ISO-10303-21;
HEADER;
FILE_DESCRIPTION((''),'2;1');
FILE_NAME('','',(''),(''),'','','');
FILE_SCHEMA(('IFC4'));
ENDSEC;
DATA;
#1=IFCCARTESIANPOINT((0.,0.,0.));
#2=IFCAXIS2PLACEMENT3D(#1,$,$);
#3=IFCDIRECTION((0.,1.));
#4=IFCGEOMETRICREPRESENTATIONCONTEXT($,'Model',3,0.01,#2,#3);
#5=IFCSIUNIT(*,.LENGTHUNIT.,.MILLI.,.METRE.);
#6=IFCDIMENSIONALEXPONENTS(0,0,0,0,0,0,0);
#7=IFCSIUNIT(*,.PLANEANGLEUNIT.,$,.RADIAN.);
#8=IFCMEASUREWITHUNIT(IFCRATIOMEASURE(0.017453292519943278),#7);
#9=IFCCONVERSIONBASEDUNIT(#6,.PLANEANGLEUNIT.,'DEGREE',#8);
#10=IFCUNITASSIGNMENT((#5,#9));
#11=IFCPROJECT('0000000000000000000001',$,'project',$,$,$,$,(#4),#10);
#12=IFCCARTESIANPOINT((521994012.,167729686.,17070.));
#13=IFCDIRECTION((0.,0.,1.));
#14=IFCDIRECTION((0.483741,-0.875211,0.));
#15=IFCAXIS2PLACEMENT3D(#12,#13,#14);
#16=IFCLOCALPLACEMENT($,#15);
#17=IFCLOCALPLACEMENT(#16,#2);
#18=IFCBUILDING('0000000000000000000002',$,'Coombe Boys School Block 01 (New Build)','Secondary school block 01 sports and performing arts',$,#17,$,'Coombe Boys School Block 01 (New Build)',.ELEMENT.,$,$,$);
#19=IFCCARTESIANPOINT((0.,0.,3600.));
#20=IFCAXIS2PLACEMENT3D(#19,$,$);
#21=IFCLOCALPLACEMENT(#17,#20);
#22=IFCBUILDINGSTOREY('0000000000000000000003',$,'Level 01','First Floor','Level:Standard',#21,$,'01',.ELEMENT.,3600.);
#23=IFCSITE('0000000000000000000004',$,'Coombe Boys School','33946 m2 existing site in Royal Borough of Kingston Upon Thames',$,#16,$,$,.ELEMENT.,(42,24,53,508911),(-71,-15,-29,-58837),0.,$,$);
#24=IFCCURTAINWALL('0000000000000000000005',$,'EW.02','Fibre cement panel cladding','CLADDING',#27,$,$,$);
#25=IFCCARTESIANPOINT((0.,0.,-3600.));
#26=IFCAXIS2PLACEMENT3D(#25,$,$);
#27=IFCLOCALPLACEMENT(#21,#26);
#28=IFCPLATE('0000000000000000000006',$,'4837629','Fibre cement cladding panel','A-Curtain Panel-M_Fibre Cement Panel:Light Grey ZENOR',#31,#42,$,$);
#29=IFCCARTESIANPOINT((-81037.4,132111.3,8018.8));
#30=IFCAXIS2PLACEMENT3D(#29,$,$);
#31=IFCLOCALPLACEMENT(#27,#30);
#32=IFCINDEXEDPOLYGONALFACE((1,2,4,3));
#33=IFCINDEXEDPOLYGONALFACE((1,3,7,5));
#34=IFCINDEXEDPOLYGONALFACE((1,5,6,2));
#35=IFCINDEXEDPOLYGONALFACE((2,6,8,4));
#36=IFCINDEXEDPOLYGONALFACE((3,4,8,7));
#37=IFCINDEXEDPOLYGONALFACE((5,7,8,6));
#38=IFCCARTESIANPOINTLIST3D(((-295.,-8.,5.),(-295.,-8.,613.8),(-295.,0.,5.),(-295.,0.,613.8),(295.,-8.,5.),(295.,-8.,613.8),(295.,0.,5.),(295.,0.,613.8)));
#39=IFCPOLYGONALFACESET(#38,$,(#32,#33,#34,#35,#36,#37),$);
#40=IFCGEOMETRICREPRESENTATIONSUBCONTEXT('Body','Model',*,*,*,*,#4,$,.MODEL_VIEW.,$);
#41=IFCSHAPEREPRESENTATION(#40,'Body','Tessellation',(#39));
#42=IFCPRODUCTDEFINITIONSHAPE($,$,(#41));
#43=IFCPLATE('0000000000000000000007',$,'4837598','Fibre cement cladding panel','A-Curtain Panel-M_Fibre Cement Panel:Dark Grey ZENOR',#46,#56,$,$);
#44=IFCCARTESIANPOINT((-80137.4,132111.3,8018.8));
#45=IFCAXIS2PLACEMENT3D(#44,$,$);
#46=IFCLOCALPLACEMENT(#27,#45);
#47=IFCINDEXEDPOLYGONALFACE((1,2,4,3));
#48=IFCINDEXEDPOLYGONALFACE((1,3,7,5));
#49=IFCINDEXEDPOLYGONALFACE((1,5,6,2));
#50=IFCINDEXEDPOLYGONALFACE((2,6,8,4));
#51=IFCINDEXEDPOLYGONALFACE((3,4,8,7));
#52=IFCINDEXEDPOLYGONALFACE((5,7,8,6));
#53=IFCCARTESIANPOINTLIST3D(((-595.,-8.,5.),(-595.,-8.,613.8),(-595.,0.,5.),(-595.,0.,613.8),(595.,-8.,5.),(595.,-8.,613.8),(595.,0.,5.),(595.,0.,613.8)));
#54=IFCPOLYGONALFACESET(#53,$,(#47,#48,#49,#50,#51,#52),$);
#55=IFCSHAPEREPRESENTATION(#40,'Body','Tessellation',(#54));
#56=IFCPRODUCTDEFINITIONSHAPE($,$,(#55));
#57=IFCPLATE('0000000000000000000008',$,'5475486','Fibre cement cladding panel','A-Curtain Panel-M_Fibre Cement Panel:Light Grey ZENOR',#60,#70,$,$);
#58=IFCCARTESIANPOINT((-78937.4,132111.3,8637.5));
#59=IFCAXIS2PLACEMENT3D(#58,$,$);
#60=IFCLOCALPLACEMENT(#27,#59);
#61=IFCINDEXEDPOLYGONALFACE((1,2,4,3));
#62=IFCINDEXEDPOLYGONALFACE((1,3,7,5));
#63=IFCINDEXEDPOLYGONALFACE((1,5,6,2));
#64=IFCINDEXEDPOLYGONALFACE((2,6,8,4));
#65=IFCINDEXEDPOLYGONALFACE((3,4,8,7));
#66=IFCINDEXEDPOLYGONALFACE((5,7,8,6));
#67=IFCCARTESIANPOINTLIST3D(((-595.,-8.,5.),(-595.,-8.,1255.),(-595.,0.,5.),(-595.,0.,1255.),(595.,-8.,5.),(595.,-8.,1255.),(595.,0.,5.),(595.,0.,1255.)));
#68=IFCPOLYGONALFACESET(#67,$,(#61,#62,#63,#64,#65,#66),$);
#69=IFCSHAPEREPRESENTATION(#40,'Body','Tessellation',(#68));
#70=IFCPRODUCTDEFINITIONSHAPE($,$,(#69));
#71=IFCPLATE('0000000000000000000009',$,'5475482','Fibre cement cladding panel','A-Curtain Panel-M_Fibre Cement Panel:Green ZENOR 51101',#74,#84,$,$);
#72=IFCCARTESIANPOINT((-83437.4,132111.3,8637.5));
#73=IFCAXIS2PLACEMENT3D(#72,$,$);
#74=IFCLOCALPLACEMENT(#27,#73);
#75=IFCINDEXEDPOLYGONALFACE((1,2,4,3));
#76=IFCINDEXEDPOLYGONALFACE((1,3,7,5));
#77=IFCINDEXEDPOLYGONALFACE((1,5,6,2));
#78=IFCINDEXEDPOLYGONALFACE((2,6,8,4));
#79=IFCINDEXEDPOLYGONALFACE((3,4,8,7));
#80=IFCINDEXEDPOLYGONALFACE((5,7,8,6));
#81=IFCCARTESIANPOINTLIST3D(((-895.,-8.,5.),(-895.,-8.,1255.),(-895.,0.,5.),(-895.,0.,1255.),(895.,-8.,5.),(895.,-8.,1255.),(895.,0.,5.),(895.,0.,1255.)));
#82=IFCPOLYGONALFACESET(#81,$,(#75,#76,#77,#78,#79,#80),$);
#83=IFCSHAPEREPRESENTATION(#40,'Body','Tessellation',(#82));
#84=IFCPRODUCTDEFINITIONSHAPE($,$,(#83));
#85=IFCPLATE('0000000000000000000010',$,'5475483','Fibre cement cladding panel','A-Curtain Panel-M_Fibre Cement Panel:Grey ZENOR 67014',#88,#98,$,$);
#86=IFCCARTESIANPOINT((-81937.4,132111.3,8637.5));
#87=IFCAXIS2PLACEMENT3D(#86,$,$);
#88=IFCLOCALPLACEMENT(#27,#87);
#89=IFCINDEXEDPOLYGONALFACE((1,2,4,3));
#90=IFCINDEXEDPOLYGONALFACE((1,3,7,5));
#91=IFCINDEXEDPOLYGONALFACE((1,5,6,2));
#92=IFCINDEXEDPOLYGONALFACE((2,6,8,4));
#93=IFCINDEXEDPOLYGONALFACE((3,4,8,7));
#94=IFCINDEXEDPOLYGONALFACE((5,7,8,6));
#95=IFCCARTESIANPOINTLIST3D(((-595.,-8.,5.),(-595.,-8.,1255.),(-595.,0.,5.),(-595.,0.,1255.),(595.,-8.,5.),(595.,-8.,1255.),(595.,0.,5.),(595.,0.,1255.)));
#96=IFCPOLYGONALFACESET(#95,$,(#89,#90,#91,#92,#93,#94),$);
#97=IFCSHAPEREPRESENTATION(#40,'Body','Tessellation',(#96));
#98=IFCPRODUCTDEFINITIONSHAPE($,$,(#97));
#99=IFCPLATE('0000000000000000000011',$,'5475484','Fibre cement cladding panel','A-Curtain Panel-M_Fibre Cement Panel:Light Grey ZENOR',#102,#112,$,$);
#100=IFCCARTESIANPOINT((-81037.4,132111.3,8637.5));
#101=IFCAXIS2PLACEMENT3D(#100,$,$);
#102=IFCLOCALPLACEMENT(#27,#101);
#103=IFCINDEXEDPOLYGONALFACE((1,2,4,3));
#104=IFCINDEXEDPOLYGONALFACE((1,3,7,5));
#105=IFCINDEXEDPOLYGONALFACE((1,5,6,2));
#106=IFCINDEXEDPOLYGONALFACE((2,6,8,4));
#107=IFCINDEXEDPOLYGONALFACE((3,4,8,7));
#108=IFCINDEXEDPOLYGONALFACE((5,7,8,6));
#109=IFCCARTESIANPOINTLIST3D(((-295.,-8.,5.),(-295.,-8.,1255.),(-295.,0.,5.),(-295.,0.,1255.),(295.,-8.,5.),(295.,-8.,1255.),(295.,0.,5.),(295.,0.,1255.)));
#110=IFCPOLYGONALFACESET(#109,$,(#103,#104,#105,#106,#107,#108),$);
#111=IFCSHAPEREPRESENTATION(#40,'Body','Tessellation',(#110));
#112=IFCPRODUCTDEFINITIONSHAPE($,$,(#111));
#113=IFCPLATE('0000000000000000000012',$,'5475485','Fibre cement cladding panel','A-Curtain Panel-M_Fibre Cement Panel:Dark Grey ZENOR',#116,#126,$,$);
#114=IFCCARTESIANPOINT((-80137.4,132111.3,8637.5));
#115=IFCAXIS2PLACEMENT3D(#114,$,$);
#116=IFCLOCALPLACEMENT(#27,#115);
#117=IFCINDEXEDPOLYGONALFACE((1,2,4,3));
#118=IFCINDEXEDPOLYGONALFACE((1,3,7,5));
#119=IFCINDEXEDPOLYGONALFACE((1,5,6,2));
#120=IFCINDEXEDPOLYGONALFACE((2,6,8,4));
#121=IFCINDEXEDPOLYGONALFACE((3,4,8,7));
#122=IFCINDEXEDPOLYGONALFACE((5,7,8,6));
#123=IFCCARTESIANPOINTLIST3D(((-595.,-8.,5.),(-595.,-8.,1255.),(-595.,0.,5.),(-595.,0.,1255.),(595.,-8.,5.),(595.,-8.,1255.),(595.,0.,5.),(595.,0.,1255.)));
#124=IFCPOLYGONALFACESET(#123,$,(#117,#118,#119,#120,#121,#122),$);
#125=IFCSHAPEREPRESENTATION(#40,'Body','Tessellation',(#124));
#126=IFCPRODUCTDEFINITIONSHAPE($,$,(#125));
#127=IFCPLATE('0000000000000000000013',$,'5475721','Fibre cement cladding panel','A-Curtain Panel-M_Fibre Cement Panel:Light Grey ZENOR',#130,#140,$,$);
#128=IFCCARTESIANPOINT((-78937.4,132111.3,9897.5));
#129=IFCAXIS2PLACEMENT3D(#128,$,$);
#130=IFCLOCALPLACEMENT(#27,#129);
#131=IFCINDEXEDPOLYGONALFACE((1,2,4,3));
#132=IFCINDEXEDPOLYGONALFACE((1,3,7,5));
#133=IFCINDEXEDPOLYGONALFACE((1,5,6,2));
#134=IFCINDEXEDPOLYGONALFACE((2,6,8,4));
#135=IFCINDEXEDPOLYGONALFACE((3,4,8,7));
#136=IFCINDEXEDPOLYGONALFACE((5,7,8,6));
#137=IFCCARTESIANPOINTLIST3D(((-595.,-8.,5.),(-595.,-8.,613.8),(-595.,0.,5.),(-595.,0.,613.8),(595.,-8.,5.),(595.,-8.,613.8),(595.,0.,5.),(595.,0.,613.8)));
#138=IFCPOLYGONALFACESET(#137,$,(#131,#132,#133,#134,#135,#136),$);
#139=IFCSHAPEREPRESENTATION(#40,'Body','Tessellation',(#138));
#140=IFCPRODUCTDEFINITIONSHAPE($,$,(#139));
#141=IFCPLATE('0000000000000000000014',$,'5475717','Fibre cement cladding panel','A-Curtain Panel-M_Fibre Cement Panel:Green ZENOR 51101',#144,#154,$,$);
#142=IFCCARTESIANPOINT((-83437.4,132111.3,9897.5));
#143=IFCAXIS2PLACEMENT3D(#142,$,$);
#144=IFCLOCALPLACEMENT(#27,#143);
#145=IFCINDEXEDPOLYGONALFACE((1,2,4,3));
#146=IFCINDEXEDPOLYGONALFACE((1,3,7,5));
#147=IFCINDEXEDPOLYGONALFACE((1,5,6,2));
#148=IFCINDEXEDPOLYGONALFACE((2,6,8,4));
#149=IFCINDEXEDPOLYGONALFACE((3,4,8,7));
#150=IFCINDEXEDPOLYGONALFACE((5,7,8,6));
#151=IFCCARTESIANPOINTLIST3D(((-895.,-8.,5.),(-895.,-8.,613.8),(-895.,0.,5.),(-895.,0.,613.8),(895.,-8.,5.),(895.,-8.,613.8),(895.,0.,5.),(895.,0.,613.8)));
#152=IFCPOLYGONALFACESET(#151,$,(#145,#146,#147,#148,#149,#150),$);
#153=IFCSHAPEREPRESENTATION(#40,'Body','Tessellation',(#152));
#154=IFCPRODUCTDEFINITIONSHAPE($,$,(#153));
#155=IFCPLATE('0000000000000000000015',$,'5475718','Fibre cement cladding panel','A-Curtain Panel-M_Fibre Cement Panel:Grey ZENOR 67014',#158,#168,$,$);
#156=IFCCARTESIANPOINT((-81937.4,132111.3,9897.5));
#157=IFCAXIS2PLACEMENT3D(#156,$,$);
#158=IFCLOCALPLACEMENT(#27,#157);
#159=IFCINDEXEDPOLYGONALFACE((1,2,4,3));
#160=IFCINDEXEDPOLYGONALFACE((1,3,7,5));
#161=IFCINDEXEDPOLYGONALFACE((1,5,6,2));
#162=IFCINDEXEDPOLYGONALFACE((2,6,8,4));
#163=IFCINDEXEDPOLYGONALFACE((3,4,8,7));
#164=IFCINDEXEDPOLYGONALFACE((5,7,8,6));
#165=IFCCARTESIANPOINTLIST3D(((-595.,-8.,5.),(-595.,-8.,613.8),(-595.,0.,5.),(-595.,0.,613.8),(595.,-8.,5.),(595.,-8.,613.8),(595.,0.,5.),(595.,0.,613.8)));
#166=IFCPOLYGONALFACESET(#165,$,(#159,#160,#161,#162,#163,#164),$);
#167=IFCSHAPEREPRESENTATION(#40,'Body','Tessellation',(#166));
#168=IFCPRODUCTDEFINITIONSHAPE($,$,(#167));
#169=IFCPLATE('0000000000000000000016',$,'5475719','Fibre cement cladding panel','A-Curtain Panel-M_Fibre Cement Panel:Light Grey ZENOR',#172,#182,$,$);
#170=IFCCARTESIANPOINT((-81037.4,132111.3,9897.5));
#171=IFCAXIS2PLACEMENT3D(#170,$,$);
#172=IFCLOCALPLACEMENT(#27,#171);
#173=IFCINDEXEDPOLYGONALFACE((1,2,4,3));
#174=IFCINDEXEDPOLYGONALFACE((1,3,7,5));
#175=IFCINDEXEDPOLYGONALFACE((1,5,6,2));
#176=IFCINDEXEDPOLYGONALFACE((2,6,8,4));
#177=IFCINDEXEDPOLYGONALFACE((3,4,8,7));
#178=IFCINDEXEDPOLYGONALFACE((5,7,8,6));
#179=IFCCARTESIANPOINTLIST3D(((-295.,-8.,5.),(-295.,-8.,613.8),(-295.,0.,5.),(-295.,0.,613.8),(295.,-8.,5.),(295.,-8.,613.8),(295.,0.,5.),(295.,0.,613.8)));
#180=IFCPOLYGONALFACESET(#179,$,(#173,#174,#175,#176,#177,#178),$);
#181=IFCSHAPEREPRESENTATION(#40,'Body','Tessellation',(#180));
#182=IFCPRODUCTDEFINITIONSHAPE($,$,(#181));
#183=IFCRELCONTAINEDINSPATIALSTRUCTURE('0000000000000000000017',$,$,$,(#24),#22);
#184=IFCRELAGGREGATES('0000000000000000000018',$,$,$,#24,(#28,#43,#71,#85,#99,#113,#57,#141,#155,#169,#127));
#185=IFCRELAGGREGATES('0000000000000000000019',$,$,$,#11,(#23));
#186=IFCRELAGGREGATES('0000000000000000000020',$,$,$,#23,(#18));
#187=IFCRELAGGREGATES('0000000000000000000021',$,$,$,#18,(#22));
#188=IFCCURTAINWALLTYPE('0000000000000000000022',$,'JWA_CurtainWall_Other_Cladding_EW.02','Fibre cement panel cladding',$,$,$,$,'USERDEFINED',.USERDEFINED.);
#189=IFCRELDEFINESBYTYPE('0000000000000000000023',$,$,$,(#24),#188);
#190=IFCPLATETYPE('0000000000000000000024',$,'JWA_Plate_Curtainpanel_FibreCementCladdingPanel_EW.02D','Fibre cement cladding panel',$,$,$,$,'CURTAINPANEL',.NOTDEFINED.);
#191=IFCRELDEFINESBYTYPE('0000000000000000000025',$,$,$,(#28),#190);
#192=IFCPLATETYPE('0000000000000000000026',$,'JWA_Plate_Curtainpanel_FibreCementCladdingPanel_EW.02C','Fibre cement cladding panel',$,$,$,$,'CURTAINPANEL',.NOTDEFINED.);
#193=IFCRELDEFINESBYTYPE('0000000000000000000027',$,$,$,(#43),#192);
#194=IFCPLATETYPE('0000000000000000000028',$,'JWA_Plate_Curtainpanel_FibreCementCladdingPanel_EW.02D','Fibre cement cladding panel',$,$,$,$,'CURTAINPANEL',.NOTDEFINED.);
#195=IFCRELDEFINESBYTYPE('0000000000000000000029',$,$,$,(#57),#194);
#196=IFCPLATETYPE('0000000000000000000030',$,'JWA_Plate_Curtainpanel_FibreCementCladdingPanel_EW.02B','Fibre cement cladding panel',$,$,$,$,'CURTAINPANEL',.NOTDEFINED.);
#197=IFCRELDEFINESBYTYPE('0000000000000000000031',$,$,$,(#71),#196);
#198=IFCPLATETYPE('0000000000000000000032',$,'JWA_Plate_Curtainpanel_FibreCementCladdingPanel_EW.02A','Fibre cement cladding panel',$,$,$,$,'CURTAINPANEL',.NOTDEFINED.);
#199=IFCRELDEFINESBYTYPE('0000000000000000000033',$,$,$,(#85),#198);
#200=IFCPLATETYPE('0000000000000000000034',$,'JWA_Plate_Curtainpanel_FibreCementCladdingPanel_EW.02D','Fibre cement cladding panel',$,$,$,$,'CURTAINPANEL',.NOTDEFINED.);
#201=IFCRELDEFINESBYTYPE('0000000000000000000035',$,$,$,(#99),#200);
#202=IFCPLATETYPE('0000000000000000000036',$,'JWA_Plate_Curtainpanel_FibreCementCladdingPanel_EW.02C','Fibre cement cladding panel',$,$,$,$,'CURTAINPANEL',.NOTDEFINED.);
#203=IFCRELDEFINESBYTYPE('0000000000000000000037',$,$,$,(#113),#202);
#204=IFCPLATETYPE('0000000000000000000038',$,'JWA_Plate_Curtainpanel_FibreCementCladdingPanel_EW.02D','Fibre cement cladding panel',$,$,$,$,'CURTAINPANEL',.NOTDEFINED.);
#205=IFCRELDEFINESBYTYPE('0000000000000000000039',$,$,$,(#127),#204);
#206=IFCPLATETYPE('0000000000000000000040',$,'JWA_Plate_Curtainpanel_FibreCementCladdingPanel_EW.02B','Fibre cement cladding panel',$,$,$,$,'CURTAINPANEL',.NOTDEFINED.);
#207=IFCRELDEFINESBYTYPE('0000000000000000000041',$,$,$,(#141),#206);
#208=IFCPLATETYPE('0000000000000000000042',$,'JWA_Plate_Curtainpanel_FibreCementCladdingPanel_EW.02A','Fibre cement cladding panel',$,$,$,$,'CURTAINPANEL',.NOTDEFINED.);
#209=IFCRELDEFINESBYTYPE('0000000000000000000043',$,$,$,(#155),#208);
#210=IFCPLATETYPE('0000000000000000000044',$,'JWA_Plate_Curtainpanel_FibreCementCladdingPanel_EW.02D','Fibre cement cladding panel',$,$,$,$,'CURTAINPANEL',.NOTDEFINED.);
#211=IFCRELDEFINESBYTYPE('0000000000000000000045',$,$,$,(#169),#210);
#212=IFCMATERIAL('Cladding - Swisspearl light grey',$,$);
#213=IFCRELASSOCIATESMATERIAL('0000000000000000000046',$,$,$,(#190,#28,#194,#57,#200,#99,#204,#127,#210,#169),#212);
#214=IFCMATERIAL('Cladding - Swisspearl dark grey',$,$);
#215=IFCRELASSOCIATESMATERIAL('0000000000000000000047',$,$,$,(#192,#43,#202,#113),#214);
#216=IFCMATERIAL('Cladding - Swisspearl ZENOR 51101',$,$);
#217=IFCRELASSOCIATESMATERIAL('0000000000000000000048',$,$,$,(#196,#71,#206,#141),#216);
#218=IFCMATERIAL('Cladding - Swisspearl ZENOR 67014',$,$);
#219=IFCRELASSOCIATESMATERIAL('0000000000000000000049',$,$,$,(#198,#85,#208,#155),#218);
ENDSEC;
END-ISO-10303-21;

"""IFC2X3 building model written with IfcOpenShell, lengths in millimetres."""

from ifc_helpers import new_model, entity, si_unit, converted_unit, direction, frame, origin, origin_2d_with_axis, place, context, subcontext, project, spatial, rectangle, extrude, source, transform, mapped, material, type_object, type_shapes, element, aggregate, save


model = new_model("IFC2X3")

# Units and contexts
model_context = context("Model", 3, precision=0.01, world=origin(), true_north=direction((0.0, 1.0)))
body_context = subcontext(model_context, "Body", "Model", "MODEL_VIEW")
ifc_project = project(units=[si_unit("LENGTHUNIT", "METRE", prefix="MILLI"), converted_unit("PLANEANGLEUNIT", "DEGREE", entity("IfcRatioMeasure", 0.017453292519943278), si_unit("PLANEANGLEUNIT", "RADIAN"), dimensions=[0, 0, 0, 0, 0, 0, 0])], contexts=[model_context])

# Site, building, storey
site_placement = place(None, frame((521994012.0, 167729686.0, 17070.0), z_axis=(0.0, 0.0, 1.0), x_axis=(0.483741, -0.875211, 0.0)))
site = spatial("IfcSite", under=ifc_project, at=site_placement, Name="Coombe Boys School", Description="33946 m2 existing site in Royal Borough of Kingston Upon Thames", CompositionType="ELEMENT", RefLatitude=(42, 24, 53, 508911), RefLongitude=(-71, -15, -29, -58837), RefElevation=0.0)
building_placement = place(site_placement, origin())
building = spatial("IfcBuilding", under=site, at=building_placement, Name="Coombe Boys School Block 01 (New Build)", Description="Secondary school block 01 sports and performing arts", LongName="Coombe Boys School Block 01 (New Build)", CompositionType="ELEMENT")
storey_placement = place(building_placement, frame((0.0, 0.0, 3600.0)))
storey = spatial("IfcBuildingStorey", under=building, at=storey_placement, Name="Level 01", Description="First Floor", ObjectType="Level:Standard", LongName="01", CompositionType="ELEMENT", Elevation=3600.0)

# Curtain wall, plates
curtain_wall_type = type_object("IfcCurtainWallType", Name="JWA_CurtainWall_Other_Cladding_EW.02", Description="Fibre cement panel cladding", ElementType="USERDEFINED", PredefinedType="USERDEFINED")
curtain_wall_placement = place(storey_placement, frame((0.0, 0.0, -3600.0)))
curtain_wall = element("IfcCurtainWall", 1, at=curtain_wall_placement, inside=storey, type_object=curtain_wall_type, Name="EW.02", Description="Fibre cement panel cladding", ObjectType="CLADDING")
ifc_material_1 = material(Name="Cladding - Swisspearl light grey")
plate_type_1 = type_object("IfcPlateType", Name="JWA_Plate_Curtainpanel_FibreCementCladdingPanel_EW.02D", Description="Fibre cement cladding panel", ElementType="CURTAINPANEL", PredefinedType="NOTDEFINED", material=ifc_material_1)
shared_shape_1 = source(origin(), body_context, "Body", "SweptSolid", [
    extrude(rectangle(XDim=590.0, YDim=8.0, at=origin_2d_with_axis()), frame((0.0, -4.0, 5.0), z_axis=(0.0, 0.0, 1.0), x_axis=(-1.0, 0.0, 0.0)), (0.0, 0.0, 1.0), 608.8),
])
type_shapes(plate_type_1, [shared_shape_1])
plate_1_placement = place(curtain_wall_placement, frame((-81037.4, 132111.3, 8018.8)))
plate_1 = element("IfcPlate", 2, at=plate_1_placement, type_object=plate_type_1, material=ifc_material_1, Name="4837629", Description="Fibre cement cladding panel", ObjectType="A-Curtain Panel-M_Fibre Cement Panel:Light Grey ZENOR", context=body_context, shape_type="MappedRepresentation", body=[
    mapped(shared_shape_1, transform((0.0, 0.0, 0.0), scale=1.0)),
])
ifc_material_2 = material(Name="Cladding - Swisspearl dark grey")
plate_type_2 = type_object("IfcPlateType", Name="JWA_Plate_Curtainpanel_FibreCementCladdingPanel_EW.02C", Description="Fibre cement cladding panel", ElementType="CURTAINPANEL", PredefinedType="NOTDEFINED", material=ifc_material_2)
shared_shape_2 = source(origin(), body_context, "Body", "SweptSolid", [
    extrude(rectangle(XDim=1190.0, YDim=8.0, at=origin_2d_with_axis()), frame((0.0, -4.0, 5.0), z_axis=(0.0, 0.0, 1.0), x_axis=(-1.0, 0.0, 0.0)), (0.0, 0.0, 1.0), 608.8),
])
type_shapes(plate_type_2, [shared_shape_2])
plate_2_placement = place(curtain_wall_placement, frame((-80137.4, 132111.3, 8018.8)))
plate_2 = element("IfcPlate", 3, at=plate_2_placement, type_object=plate_type_2, material=ifc_material_2, Name="4837598", Description="Fibre cement cladding panel", ObjectType="A-Curtain Panel-M_Fibre Cement Panel:Dark Grey ZENOR", context=body_context, shape_type="MappedRepresentation", body=[
    mapped(shared_shape_2, transform((0.0, 0.0, 0.0), scale=1.0)),
])
plate_type_3 = type_object("IfcPlateType", Name="JWA_Plate_Curtainpanel_FibreCementCladdingPanel_EW.02D", Description="Fibre cement cladding panel", ElementType="CURTAINPANEL", PredefinedType="NOTDEFINED", material=ifc_material_1)
shared_shape_3 = source(origin(), body_context, "Body", "SweptSolid", [
    extrude(rectangle(XDim=1190.0, YDim=8.0, at=origin_2d_with_axis()), frame((0.0, -4.0, 5.0), z_axis=(0.0, 0.0, 1.0), x_axis=(-1.0, 0.0, 0.0)), (0.0, 0.0, 1.0), 1250.0),
])
type_shapes(plate_type_3, [shared_shape_3])
plate_3_placement = place(curtain_wall_placement, frame((-78937.4, 132111.3, 8637.5)))
plate_3 = element("IfcPlate", 4, at=plate_3_placement, type_object=plate_type_3, material=ifc_material_1, Name="5475486", Description="Fibre cement cladding panel", ObjectType="A-Curtain Panel-M_Fibre Cement Panel:Light Grey ZENOR", context=body_context, shape_type="MappedRepresentation", body=[
    mapped(shared_shape_3, transform((0.0, 0.0, 0.0), scale=1.0)),
])
ifc_material_3 = material(Name="Cladding - Swisspearl ZENOR 51101")
plate_type_4 = type_object("IfcPlateType", Name="JWA_Plate_Curtainpanel_FibreCementCladdingPanel_EW.02B", Description="Fibre cement cladding panel", ElementType="CURTAINPANEL", PredefinedType="NOTDEFINED", material=ifc_material_3)
shared_shape_4 = source(origin(), body_context, "Body", "SweptSolid", [
    extrude(rectangle(XDim=1790.0, YDim=8.0, at=origin_2d_with_axis()), frame((0.0, -4.0, 5.0), z_axis=(0.0, 0.0, 1.0), x_axis=(-1.0, 0.0, 0.0)), (0.0, 0.0, 1.0), 1250.0),
])
type_shapes(plate_type_4, [shared_shape_4])
plate_4_placement = place(curtain_wall_placement, frame((-83437.4, 132111.3, 8637.5)))
plate_4 = element("IfcPlate", 5, at=plate_4_placement, type_object=plate_type_4, material=ifc_material_3, Name="5475482", Description="Fibre cement cladding panel", ObjectType="A-Curtain Panel-M_Fibre Cement Panel:Green ZENOR 51101", context=body_context, shape_type="MappedRepresentation", body=[
    mapped(shared_shape_4, transform((0.0, 0.0, 0.0), scale=1.0)),
])
ifc_material_4 = material(Name="Cladding - Swisspearl ZENOR 67014")
plate_type_5 = type_object("IfcPlateType", Name="JWA_Plate_Curtainpanel_FibreCementCladdingPanel_EW.02A", Description="Fibre cement cladding panel", ElementType="CURTAINPANEL", PredefinedType="NOTDEFINED", material=ifc_material_4)
shared_shape_5 = source(origin(), body_context, "Body", "SweptSolid", [
    extrude(rectangle(XDim=1190.0, YDim=8.0, at=origin_2d_with_axis()), frame((0.0, -4.0, 5.0), z_axis=(0.0, 0.0, 1.0), x_axis=(-1.0, 0.0, 0.0)), (0.0, 0.0, 1.0), 1250.0),
])
type_shapes(plate_type_5, [shared_shape_5])
plate_5_placement = place(curtain_wall_placement, frame((-81937.4, 132111.3, 8637.5)))
plate_5 = element("IfcPlate", 6, at=plate_5_placement, type_object=plate_type_5, material=ifc_material_4, Name="5475483", Description="Fibre cement cladding panel", ObjectType="A-Curtain Panel-M_Fibre Cement Panel:Grey ZENOR 67014", context=body_context, shape_type="MappedRepresentation", body=[
    mapped(shared_shape_5, transform((0.0, 0.0, 0.0), scale=1.0)),
])
plate_type_6 = type_object("IfcPlateType", Name="JWA_Plate_Curtainpanel_FibreCementCladdingPanel_EW.02D", Description="Fibre cement cladding panel", ElementType="CURTAINPANEL", PredefinedType="NOTDEFINED", material=ifc_material_1)
shared_shape_6 = source(origin(), body_context, "Body", "SweptSolid", [
    extrude(rectangle(XDim=590.0, YDim=8.0, at=origin_2d_with_axis()), frame((0.0, -4.0, 5.0), z_axis=(0.0, 0.0, 1.0), x_axis=(-1.0, 0.0, 0.0)), (0.0, 0.0, 1.0), 1250.0),
])
type_shapes(plate_type_6, [shared_shape_6])
plate_6_placement = place(curtain_wall_placement, frame((-81037.4, 132111.3, 8637.5)))
plate_6 = element("IfcPlate", 7, at=plate_6_placement, type_object=plate_type_6, material=ifc_material_1, Name="5475484", Description="Fibre cement cladding panel", ObjectType="A-Curtain Panel-M_Fibre Cement Panel:Light Grey ZENOR", context=body_context, shape_type="MappedRepresentation", body=[
    mapped(shared_shape_6, transform((0.0, 0.0, 0.0), scale=1.0)),
])
plate_type_7 = type_object("IfcPlateType", Name="JWA_Plate_Curtainpanel_FibreCementCladdingPanel_EW.02C", Description="Fibre cement cladding panel", ElementType="CURTAINPANEL", PredefinedType="NOTDEFINED", material=ifc_material_2)
shared_shape_7 = source(origin(), body_context, "Body", "SweptSolid", [
    extrude(rectangle(XDim=1190.0, YDim=8.0, at=origin_2d_with_axis()), frame((0.0, -4.0, 5.0), z_axis=(0.0, 0.0, 1.0), x_axis=(-1.0, 0.0, 0.0)), (0.0, 0.0, 1.0), 1250.0),
])
type_shapes(plate_type_7, [shared_shape_7])
plate_7_placement = place(curtain_wall_placement, frame((-80137.4, 132111.3, 8637.5)))
plate_7 = element("IfcPlate", 8, at=plate_7_placement, type_object=plate_type_7, material=ifc_material_2, Name="5475485", Description="Fibre cement cladding panel", ObjectType="A-Curtain Panel-M_Fibre Cement Panel:Dark Grey ZENOR", context=body_context, shape_type="MappedRepresentation", body=[
    mapped(shared_shape_7, transform((0.0, 0.0, 0.0), scale=1.0)),
])
plate_type_8 = type_object("IfcPlateType", Name="JWA_Plate_Curtainpanel_FibreCementCladdingPanel_EW.02D", Description="Fibre cement cladding panel", ElementType="CURTAINPANEL", PredefinedType="NOTDEFINED", material=ifc_material_1)
shared_shape_8 = source(origin(), body_context, "Body", "SweptSolid", [
    extrude(rectangle(XDim=1190.0, YDim=8.0, at=origin_2d_with_axis()), frame((0.0, -4.0, 5.0), z_axis=(0.0, 0.0, 1.0), x_axis=(-1.0, 0.0, 0.0)), (0.0, 0.0, 1.0), 608.8),
])
type_shapes(plate_type_8, [shared_shape_8])
plate_8_placement = place(curtain_wall_placement, frame((-78937.4, 132111.3, 9897.5)))
plate_8 = element("IfcPlate", 9, at=plate_8_placement, type_object=plate_type_8, material=ifc_material_1, Name="5475721", Description="Fibre cement cladding panel", ObjectType="A-Curtain Panel-M_Fibre Cement Panel:Light Grey ZENOR", context=body_context, shape_type="MappedRepresentation", body=[
    mapped(shared_shape_8, transform((0.0, 0.0, 0.0), scale=1.0)),
])
plate_type_9 = type_object("IfcPlateType", Name="JWA_Plate_Curtainpanel_FibreCementCladdingPanel_EW.02B", Description="Fibre cement cladding panel", ElementType="CURTAINPANEL", PredefinedType="NOTDEFINED", material=ifc_material_3)
shared_shape_9 = source(origin(), body_context, "Body", "SweptSolid", [
    extrude(rectangle(XDim=1790.0, YDim=8.0, at=origin_2d_with_axis()), frame((0.0, -4.0, 5.0), z_axis=(0.0, 0.0, 1.0), x_axis=(-1.0, 0.0, 0.0)), (0.0, 0.0, 1.0), 608.8),
])
type_shapes(plate_type_9, [shared_shape_9])
plate_9_placement = place(curtain_wall_placement, frame((-83437.4, 132111.3, 9897.5)))
plate_9 = element("IfcPlate", 10, at=plate_9_placement, type_object=plate_type_9, material=ifc_material_3, Name="5475717", Description="Fibre cement cladding panel", ObjectType="A-Curtain Panel-M_Fibre Cement Panel:Green ZENOR 51101", context=body_context, shape_type="MappedRepresentation", body=[
    mapped(shared_shape_9, transform((0.0, 0.0, 0.0), scale=1.0)),
])
plate_type_10 = type_object("IfcPlateType", Name="JWA_Plate_Curtainpanel_FibreCementCladdingPanel_EW.02A", Description="Fibre cement cladding panel", ElementType="CURTAINPANEL", PredefinedType="NOTDEFINED", material=ifc_material_4)
shared_shape_10 = source(origin(), body_context, "Body", "SweptSolid", [
    extrude(rectangle(XDim=1190.0, YDim=8.0, at=origin_2d_with_axis()), frame((0.0, -4.0, 5.0), z_axis=(0.0, 0.0, 1.0), x_axis=(-1.0, 0.0, 0.0)), (0.0, 0.0, 1.0), 608.8),
])
type_shapes(plate_type_10, [shared_shape_10])
plate_10_placement = place(curtain_wall_placement, frame((-81937.4, 132111.3, 9897.5)))
plate_10 = element("IfcPlate", 11, at=plate_10_placement, type_object=plate_type_10, material=ifc_material_4, Name="5475718", Description="Fibre cement cladding panel", ObjectType="A-Curtain Panel-M_Fibre Cement Panel:Grey ZENOR 67014", context=body_context, shape_type="MappedRepresentation", body=[
    mapped(shared_shape_10, transform((0.0, 0.0, 0.0), scale=1.0)),
])
plate_type_11 = type_object("IfcPlateType", Name="JWA_Plate_Curtainpanel_FibreCementCladdingPanel_EW.02D", Description="Fibre cement cladding panel", ElementType="CURTAINPANEL", PredefinedType="NOTDEFINED", material=ifc_material_1)
shared_shape_11 = source(origin(), body_context, "Body", "SweptSolid", [
    extrude(rectangle(XDim=590.0, YDim=8.0, at=origin_2d_with_axis()), frame((0.0, -4.0, 5.0), z_axis=(0.0, 0.0, 1.0), x_axis=(-1.0, 0.0, 0.0)), (0.0, 0.0, 1.0), 608.8),
])
type_shapes(plate_type_11, [shared_shape_11])
plate_11_placement = place(curtain_wall_placement, frame((-81037.4, 132111.3, 9897.5)))
plate_11 = element("IfcPlate", 12, at=plate_11_placement, type_object=plate_type_11, material=ifc_material_1, Name="5475719", Description="Fibre cement cladding panel", ObjectType="A-Curtain Panel-M_Fibre Cement Panel:Light Grey ZENOR", context=body_context, shape_type="MappedRepresentation", body=[
    mapped(shared_shape_11, transform((0.0, 0.0, 0.0), scale=1.0)),
])
aggregate(curtain_wall, [plate_1, plate_2, plate_4, plate_5, plate_6, plate_7, plate_3, plate_9, plate_10, plate_11, plate_8])

save(model, "model.ifc")
